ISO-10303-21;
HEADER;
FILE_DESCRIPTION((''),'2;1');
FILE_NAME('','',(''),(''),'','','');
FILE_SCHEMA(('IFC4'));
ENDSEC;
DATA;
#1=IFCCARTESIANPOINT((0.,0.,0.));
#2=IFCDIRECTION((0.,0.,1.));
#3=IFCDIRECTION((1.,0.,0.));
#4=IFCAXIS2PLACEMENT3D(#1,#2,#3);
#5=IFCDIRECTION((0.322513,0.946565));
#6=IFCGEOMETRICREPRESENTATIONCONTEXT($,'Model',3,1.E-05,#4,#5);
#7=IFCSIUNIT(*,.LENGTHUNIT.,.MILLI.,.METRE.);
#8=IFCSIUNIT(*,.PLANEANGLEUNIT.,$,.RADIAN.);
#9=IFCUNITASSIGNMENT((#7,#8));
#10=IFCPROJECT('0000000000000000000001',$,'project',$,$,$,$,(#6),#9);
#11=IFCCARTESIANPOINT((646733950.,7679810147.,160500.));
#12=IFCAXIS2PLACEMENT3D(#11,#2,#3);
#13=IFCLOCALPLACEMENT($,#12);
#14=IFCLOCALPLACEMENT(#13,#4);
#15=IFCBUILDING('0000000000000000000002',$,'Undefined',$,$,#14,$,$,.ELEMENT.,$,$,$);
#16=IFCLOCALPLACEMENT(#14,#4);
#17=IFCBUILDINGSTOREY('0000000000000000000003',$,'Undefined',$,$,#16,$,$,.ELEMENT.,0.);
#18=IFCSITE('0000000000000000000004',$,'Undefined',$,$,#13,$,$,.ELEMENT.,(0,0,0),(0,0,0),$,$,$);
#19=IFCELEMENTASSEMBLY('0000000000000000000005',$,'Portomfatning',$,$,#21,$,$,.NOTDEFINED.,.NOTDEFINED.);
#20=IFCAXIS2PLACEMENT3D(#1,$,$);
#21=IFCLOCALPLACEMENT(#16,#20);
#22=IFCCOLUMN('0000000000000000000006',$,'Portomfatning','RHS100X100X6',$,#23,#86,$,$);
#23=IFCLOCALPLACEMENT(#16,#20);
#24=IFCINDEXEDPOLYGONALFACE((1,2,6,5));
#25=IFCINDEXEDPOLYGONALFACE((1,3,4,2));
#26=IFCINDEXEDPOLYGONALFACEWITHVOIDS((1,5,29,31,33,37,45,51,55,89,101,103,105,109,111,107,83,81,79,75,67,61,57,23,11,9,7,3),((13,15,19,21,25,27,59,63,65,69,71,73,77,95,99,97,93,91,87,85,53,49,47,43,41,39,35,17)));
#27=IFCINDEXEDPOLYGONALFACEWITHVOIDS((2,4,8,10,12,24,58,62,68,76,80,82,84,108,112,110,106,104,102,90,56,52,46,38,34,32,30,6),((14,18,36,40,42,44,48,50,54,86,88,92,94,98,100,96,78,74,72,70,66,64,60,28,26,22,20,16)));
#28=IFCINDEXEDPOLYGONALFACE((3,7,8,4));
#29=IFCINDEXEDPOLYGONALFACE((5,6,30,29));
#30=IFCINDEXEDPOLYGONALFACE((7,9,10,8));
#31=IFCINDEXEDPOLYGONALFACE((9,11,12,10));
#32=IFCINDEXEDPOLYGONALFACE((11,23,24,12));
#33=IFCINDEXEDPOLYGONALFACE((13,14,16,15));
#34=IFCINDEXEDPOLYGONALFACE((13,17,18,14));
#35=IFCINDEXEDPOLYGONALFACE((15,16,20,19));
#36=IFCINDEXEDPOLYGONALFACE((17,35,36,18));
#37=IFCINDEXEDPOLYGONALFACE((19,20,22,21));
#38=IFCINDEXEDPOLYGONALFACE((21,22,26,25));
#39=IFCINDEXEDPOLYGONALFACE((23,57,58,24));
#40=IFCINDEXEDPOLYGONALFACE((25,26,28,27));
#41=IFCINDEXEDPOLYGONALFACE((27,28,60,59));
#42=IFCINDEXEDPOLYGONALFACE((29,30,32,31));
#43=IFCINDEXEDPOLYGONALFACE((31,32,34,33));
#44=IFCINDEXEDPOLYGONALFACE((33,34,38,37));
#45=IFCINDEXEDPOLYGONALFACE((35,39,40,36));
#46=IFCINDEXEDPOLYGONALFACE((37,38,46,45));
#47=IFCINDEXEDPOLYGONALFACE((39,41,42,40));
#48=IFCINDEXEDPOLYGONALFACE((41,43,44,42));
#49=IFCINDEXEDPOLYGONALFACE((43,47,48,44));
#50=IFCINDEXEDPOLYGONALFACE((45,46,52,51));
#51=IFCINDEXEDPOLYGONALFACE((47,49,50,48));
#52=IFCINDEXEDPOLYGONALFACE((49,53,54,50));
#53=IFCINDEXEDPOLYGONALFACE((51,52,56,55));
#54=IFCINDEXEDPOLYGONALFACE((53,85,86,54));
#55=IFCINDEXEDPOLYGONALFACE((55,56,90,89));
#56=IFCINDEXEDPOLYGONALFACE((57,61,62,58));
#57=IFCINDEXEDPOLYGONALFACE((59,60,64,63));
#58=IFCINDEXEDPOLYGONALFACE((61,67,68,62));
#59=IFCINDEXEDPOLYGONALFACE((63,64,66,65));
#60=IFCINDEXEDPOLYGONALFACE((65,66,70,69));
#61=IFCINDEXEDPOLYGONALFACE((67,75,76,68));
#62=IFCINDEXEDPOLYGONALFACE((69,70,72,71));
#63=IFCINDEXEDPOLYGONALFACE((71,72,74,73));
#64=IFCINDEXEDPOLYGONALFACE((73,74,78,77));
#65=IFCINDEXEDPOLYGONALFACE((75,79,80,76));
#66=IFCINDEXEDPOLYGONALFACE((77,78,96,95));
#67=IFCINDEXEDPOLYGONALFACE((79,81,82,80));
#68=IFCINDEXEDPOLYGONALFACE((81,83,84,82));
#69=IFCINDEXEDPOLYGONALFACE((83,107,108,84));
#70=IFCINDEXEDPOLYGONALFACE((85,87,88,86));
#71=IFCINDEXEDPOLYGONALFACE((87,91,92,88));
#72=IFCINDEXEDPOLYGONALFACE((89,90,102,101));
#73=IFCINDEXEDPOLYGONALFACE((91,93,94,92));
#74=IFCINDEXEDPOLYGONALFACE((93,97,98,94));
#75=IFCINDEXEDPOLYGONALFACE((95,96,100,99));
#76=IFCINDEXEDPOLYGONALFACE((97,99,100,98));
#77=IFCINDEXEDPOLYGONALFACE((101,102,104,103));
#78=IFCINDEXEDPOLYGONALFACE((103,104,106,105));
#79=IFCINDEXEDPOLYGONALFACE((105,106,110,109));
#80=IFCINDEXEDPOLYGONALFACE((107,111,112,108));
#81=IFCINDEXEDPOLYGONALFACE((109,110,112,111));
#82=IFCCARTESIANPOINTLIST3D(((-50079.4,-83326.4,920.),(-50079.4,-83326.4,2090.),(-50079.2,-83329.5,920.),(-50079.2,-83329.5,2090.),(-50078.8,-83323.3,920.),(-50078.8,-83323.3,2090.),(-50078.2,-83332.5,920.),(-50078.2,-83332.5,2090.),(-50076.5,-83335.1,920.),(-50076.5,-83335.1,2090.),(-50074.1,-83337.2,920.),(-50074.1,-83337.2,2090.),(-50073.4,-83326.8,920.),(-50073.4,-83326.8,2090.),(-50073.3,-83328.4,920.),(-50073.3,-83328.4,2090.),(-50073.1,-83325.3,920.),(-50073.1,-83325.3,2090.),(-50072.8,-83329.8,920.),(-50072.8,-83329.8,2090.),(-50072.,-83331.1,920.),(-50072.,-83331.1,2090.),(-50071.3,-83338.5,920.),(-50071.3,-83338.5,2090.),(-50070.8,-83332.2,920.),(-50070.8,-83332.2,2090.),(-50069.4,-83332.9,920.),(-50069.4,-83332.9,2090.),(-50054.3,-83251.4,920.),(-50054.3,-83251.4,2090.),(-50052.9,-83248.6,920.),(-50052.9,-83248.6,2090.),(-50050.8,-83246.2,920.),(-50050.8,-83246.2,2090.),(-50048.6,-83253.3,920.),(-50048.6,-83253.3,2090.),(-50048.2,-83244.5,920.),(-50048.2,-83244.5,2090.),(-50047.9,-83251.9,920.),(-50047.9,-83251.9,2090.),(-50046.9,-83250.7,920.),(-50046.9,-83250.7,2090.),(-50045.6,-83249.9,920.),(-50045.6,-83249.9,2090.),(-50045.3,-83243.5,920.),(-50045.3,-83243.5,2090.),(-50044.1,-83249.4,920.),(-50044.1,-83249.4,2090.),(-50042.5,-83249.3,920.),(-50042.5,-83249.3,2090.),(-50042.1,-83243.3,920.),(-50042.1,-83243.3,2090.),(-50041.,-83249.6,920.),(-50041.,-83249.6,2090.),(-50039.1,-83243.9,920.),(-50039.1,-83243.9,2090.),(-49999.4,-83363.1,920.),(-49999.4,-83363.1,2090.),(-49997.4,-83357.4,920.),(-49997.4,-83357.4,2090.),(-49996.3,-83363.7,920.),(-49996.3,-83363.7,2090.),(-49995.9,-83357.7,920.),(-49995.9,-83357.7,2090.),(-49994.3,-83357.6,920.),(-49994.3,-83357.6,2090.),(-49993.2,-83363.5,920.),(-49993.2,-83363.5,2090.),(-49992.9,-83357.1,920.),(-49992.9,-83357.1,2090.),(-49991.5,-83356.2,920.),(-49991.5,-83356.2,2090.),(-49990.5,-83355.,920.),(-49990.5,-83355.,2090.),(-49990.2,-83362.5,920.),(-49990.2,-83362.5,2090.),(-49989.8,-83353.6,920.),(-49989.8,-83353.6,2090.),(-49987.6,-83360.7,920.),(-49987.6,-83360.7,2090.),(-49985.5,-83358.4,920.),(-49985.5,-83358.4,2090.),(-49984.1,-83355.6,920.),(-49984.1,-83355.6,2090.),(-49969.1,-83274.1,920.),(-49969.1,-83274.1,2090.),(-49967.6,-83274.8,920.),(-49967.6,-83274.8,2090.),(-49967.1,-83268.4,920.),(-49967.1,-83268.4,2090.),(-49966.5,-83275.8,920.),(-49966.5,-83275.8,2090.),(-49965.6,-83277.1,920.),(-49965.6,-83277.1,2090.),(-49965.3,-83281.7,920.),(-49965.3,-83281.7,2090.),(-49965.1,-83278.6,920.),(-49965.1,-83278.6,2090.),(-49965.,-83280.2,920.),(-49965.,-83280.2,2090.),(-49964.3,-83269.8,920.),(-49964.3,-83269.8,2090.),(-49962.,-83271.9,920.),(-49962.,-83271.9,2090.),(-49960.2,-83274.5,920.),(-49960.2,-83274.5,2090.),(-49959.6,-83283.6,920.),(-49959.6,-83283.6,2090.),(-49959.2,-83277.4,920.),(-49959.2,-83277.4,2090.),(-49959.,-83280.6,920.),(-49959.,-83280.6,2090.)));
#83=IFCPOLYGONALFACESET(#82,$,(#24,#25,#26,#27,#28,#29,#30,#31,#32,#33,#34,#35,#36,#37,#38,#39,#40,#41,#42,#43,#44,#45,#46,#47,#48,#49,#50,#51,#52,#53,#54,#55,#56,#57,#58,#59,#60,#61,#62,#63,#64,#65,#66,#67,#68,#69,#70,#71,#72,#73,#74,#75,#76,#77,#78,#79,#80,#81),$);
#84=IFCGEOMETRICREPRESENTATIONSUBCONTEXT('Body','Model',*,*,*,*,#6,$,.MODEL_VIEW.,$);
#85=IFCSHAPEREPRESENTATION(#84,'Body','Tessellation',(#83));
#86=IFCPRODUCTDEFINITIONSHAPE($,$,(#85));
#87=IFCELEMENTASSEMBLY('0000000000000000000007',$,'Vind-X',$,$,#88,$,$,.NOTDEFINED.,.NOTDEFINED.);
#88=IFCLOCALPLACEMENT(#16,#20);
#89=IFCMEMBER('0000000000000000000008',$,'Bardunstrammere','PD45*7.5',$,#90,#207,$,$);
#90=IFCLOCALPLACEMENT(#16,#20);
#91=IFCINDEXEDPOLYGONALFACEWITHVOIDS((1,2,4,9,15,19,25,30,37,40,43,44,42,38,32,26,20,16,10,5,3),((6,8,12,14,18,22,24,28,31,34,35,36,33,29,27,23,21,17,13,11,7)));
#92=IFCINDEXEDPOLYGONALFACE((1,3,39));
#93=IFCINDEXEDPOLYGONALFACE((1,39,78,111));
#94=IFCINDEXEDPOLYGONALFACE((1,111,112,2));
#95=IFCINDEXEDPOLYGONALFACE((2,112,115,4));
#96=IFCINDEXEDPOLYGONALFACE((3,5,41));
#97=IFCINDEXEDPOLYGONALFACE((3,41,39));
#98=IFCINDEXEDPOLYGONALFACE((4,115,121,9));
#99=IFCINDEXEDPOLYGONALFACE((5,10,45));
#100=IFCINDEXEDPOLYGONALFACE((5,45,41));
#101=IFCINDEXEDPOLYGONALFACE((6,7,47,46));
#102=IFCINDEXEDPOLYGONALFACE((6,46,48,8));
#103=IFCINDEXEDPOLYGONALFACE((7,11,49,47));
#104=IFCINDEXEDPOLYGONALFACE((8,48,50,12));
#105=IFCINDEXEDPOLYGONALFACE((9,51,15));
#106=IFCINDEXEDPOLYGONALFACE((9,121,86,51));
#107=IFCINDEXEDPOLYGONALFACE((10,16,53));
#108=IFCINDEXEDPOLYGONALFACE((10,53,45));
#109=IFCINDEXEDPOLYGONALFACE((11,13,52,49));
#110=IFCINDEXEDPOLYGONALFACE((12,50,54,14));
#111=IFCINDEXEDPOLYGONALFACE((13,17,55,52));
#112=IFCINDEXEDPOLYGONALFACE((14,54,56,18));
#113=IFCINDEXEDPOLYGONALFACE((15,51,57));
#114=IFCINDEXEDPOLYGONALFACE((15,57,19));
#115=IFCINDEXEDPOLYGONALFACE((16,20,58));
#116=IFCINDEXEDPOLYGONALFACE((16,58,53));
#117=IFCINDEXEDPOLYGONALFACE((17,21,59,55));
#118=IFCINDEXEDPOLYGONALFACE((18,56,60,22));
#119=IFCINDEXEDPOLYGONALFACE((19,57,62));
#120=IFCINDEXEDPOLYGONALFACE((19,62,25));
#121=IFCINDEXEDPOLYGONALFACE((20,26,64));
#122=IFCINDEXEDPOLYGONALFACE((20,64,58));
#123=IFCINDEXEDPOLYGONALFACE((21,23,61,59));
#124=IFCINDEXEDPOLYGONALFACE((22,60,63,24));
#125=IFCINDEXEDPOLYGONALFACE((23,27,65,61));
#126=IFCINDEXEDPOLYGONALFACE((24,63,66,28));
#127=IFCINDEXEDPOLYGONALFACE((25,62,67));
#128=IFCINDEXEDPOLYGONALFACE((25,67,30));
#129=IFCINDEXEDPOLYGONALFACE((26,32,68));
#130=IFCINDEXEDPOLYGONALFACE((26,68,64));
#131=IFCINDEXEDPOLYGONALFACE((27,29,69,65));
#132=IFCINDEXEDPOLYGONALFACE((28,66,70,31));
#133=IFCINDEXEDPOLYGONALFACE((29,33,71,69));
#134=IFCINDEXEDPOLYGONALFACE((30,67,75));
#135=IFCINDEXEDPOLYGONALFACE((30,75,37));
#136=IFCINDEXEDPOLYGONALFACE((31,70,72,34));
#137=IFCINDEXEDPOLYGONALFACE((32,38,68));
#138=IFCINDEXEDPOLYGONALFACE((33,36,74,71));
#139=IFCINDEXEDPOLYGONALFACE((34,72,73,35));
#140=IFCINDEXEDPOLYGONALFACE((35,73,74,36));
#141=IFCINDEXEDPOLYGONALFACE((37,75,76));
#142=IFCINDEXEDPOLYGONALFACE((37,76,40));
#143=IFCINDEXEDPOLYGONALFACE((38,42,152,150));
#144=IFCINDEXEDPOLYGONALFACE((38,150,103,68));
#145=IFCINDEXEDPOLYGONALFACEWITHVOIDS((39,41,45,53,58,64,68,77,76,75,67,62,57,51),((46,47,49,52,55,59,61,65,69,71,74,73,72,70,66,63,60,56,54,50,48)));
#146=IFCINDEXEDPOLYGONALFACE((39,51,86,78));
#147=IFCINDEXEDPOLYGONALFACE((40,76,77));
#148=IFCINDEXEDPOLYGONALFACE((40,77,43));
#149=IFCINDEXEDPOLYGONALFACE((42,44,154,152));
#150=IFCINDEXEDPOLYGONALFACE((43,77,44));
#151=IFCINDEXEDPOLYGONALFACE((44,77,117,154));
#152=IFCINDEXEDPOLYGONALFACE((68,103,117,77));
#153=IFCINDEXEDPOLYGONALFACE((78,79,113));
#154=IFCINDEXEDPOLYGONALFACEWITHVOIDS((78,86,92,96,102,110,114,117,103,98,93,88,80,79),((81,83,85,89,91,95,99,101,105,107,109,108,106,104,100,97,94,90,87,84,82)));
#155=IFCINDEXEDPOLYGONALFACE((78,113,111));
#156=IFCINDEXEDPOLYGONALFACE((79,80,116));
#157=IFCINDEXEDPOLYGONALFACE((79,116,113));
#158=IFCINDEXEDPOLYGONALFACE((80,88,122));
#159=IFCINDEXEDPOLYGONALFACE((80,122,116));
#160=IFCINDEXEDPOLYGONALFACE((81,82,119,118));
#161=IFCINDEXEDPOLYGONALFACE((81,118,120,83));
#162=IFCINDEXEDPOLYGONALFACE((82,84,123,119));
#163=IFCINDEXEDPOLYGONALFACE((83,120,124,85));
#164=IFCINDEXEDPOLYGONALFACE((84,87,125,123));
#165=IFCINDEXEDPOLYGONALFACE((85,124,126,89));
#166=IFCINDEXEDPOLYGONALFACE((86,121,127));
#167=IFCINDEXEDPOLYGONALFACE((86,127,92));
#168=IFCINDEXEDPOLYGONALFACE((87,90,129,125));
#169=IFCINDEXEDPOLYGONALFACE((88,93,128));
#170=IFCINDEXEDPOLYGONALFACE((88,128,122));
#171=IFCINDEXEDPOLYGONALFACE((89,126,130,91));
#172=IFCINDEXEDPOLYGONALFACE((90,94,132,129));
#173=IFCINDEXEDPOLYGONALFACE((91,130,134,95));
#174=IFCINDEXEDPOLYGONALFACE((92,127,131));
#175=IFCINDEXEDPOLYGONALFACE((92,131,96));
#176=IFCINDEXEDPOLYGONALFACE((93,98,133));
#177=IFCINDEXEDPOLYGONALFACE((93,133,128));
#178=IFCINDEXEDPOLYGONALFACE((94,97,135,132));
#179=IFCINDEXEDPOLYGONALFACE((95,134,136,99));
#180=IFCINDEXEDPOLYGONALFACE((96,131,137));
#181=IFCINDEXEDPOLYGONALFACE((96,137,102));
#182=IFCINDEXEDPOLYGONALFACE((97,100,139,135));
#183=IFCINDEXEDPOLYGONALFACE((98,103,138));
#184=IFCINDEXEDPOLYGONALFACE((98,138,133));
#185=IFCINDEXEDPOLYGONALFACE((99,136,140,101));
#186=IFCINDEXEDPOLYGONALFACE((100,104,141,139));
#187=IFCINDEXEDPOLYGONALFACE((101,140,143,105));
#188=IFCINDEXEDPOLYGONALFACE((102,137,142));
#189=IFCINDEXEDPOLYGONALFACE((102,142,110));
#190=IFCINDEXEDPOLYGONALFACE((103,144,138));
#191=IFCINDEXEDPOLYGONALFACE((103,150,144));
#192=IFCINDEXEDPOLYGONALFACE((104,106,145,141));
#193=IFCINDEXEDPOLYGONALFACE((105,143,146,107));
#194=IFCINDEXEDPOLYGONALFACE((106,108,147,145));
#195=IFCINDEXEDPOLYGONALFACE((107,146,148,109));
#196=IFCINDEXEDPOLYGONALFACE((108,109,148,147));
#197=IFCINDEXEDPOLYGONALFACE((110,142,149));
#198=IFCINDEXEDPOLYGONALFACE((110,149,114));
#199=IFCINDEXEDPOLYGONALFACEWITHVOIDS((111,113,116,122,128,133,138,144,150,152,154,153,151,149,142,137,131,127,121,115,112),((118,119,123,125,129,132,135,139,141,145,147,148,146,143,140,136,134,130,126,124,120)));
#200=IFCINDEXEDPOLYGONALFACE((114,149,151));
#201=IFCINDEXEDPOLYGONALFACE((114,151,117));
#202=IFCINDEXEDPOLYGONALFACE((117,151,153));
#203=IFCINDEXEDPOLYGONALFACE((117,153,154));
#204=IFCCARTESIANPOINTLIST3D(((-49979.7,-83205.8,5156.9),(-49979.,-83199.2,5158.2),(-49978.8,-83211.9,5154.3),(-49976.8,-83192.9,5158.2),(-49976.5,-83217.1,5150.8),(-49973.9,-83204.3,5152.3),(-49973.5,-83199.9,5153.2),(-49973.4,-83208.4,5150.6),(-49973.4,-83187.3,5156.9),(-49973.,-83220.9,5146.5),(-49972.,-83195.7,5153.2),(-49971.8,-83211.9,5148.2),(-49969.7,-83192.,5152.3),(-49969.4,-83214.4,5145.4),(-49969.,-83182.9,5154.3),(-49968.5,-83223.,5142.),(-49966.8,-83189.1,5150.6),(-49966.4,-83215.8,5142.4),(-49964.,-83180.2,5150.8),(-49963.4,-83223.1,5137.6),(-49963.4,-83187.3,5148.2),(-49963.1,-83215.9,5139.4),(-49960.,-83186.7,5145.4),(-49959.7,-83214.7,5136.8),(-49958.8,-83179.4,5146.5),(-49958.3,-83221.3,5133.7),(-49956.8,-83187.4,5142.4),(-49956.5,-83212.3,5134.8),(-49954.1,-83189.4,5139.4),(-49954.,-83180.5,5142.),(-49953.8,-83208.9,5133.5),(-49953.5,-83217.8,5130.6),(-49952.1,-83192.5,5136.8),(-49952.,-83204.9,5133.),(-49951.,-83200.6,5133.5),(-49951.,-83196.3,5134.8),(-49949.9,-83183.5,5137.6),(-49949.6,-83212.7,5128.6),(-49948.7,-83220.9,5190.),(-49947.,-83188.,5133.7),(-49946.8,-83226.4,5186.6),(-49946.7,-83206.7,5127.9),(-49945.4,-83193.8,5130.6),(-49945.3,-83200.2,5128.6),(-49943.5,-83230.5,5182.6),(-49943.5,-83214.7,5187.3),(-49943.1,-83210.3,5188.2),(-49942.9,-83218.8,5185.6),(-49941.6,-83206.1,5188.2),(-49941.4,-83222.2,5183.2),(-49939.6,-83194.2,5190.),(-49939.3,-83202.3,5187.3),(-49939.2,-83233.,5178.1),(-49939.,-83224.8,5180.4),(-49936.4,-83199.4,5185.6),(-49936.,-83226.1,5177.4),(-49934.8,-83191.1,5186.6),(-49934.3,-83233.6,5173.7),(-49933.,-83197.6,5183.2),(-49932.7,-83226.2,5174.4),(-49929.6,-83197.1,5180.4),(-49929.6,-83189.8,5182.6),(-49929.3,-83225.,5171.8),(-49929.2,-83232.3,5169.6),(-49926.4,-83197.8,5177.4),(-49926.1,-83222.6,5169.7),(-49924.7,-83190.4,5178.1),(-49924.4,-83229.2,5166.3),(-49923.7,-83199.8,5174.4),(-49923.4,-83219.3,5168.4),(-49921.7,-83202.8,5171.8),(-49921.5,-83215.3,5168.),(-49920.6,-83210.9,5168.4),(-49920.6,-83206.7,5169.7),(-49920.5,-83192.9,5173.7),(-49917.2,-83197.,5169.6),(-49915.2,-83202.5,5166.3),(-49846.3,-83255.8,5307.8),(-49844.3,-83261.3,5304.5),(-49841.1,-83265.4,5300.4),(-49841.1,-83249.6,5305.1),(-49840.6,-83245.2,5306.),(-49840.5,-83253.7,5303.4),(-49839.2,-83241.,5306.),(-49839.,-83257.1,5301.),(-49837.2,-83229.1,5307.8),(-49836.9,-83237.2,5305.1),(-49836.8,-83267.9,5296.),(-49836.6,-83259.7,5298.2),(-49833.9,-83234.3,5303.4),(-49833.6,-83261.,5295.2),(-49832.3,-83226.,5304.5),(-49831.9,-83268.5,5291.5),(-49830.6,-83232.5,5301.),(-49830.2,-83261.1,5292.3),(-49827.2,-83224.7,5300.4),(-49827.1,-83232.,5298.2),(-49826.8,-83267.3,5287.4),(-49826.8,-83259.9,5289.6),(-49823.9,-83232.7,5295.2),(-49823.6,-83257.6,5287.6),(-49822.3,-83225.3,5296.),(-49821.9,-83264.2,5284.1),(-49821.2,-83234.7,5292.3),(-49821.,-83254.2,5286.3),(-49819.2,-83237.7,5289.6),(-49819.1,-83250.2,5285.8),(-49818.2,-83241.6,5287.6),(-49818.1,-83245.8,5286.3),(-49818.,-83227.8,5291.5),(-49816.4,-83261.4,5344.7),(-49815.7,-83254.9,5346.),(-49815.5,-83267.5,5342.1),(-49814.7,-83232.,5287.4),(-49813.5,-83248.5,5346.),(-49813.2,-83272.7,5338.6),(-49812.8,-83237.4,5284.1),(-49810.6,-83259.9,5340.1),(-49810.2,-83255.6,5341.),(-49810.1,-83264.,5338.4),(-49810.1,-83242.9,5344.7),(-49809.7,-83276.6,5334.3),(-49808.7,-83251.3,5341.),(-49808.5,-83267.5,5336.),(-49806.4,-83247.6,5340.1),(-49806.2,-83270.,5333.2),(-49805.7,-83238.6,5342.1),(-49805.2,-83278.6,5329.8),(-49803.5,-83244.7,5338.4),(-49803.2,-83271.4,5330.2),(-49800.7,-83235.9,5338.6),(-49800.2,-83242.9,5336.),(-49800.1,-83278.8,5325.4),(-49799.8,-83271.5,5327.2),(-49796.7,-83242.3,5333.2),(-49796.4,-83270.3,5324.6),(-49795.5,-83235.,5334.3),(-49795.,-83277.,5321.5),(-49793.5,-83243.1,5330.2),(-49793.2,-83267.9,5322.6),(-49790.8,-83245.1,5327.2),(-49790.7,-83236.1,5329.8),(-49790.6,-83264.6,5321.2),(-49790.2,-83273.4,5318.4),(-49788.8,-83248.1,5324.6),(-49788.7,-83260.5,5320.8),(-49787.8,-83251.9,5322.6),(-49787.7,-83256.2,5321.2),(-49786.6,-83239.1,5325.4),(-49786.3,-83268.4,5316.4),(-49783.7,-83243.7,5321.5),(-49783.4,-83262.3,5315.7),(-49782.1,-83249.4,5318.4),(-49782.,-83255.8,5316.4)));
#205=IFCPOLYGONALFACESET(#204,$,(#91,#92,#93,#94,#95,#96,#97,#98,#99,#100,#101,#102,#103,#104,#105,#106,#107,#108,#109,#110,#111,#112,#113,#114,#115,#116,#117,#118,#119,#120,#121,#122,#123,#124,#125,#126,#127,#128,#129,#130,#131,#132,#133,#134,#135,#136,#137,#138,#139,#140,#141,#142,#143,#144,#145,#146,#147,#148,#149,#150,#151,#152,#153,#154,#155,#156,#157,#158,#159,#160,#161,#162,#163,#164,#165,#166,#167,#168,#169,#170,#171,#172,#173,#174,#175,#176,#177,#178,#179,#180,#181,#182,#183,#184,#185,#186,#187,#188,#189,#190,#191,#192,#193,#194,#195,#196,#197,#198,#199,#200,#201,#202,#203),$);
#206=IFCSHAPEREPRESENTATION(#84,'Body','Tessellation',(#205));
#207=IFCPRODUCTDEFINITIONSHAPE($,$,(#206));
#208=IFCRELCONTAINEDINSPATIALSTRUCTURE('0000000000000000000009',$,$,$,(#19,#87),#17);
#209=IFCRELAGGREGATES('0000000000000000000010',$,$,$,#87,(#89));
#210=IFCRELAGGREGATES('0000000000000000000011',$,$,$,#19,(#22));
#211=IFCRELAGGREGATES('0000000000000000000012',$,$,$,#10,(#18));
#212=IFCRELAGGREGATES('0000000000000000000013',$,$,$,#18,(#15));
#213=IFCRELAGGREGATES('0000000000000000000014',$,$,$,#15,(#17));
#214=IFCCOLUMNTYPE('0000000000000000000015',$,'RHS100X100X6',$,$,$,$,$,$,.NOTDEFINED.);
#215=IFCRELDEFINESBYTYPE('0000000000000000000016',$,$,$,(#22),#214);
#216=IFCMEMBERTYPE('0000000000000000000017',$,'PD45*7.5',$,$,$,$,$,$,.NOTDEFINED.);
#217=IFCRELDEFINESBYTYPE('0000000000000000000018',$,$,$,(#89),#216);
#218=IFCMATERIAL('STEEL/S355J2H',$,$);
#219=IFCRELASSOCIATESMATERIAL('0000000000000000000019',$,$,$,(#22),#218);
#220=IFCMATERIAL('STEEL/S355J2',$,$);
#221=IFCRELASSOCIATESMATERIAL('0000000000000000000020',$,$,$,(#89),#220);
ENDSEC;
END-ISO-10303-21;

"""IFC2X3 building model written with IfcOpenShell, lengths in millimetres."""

from ifc_helpers import new_model, si_unit, direction, frame, origin_with_axes, origin_2d_with_axis, place, context, subcontext, project, spatial, rectangle, hollow_rectangle, hollow_circle, extrude, boolean, clip, halfspace, material, type_object, element, aggregate, save


model = new_model("IFC2X3")

# Units and contexts
model_context = context("Model", 3, precision=1e-05, world=origin_with_axes(), true_north=direction((0.322513, 0.946565)))
body_context = subcontext(model_context, "Body", "Model", "MODEL_VIEW")
ifc_project = project(units=[si_unit("LENGTHUNIT", "METRE", prefix="MILLI"), si_unit("PLANEANGLEUNIT", "RADIAN")], contexts=[model_context])

# Site, building, storey
site_placement = place(None, frame((646733950.0, 7679810147.0, 160500.0), z_axis=(0.0, 0.0, 1.0), x_axis=(1.0, 0.0, 0.0)))
site = spatial("IfcSite", under=ifc_project, at=site_placement, Name="Undefined", CompositionType="ELEMENT", RefLatitude=(0, 0, 0), RefLongitude=(0, 0, 0))
building_placement = place(site_placement, origin_with_axes())
building = spatial("IfcBuilding", under=site, at=building_placement, Name="Undefined", CompositionType="ELEMENT")
storey_placement = place(building_placement, origin_with_axes())
storey = spatial("IfcBuildingStorey", under=building, at=storey_placement, Name="Undefined", CompositionType="ELEMENT", Elevation=0.0)

# Element assembly, column
assembly_1_placement = place(storey_placement, origin_with_axes())
assembly_1 = element("IfcElementAssembly", 1, at=assembly_1_placement, inside=storey, Name="Portomfatning", AssemblyPlace="NOTDEFINED", PredefinedType="NOTDEFINED")
ifc_material_1 = material(Name="STEEL/S355J2H")
column_type = type_object("IfcColumnType", Name="RHS100X100X6", PredefinedType="NOTDEFINED")
column_placement = place(assembly_1_placement, frame((-50019.2, -83303.5, 910.0), z_axis=(0.0, 0.0, 1.0), x_axis=(-0.322513, -0.946565, 0.0)))
column = element("IfcColumn", 2, at=column_placement, type_object=column_type, material=ifc_material_1, Name="Portomfatning", Description="RHS100X100X6", context=body_context, shape_type="Clipping", body=[
    clip(clip(extrude(hollow_rectangle(XDim=100.0, YDim=100.0, WallThickness=6.0, InnerFilletRadius=6.0, OuterFilletRadius=12.0, at=origin_2d_with_axis()), frame((0.0, 0.0, 1190.0), z_axis=(0.0, 0.0, -1.0), x_axis=(0.0, 1.0, 0.0)), (0.0, 0.0, 1.0), 1190.0), halfspace(frame((0.0, -50.0, 1180.0), z_axis=(0.0, 0.0, -1.0), x_axis=(1.0, 0.0, 0.0)), True)), halfspace(frame((0.0, -50.0, 10.0), z_axis=(0.0, 0.0, 1.0), x_axis=(-1.0, 0.0, 0.0)), True)),
])

# Element assembly, member
assembly_2_placement = place(storey_placement, origin_with_axes())
assembly_2 = element("IfcElementAssembly", 3, at=assembly_2_placement, inside=storey, Name="Vind-X", AssemblyPlace="NOTDEFINED", PredefinedType="NOTDEFINED")
ifc_material_2 = material(Name="STEEL/S355J2")
member_type = type_object("IfcMemberType", Name="PD45*7.5", PredefinedType="NOTDEFINED")
member_placement = place(assembly_2_placement, frame((-49962.4, -83201.3, 5143.1), z_axis=(-0.322513, -0.946565, 0.0), x_axis=(0.640354, -0.218181, 0.73644)))
member = element("IfcMember", 4, at=member_placement, type_object=member_type, material=ifc_material_2, Name="Bardunstrammere", Description="PD45*7.5", context=body_context, shape_type="CSG", body=[
    boolean("DIFFERENCE", extrude(hollow_circle(Radius=22.5, WallThickness=7.5, at=origin_2d_with_axis()), frame((255.0, 0.0, 0.0), z_axis=(-1.0, 0.0, 0.0), x_axis=(0.0, -1.0, 0.0)), (0.0, 0.0, 1.0), 255.0), extrude(rectangle(XDim=35.0, YDim=90.0, at=origin_2d_with_axis()), frame((207.5, 0.0, 0.0), z_axis=(-1.0, 0.0, 0.0), x_axis=(0.0, -1.0, 0.0)), (0.0, 0.0, 1.0), 160.0)),
])
aggregate(assembly_2, [member])

aggregate(assembly_1, [column])

save(model, "model.ifc")
